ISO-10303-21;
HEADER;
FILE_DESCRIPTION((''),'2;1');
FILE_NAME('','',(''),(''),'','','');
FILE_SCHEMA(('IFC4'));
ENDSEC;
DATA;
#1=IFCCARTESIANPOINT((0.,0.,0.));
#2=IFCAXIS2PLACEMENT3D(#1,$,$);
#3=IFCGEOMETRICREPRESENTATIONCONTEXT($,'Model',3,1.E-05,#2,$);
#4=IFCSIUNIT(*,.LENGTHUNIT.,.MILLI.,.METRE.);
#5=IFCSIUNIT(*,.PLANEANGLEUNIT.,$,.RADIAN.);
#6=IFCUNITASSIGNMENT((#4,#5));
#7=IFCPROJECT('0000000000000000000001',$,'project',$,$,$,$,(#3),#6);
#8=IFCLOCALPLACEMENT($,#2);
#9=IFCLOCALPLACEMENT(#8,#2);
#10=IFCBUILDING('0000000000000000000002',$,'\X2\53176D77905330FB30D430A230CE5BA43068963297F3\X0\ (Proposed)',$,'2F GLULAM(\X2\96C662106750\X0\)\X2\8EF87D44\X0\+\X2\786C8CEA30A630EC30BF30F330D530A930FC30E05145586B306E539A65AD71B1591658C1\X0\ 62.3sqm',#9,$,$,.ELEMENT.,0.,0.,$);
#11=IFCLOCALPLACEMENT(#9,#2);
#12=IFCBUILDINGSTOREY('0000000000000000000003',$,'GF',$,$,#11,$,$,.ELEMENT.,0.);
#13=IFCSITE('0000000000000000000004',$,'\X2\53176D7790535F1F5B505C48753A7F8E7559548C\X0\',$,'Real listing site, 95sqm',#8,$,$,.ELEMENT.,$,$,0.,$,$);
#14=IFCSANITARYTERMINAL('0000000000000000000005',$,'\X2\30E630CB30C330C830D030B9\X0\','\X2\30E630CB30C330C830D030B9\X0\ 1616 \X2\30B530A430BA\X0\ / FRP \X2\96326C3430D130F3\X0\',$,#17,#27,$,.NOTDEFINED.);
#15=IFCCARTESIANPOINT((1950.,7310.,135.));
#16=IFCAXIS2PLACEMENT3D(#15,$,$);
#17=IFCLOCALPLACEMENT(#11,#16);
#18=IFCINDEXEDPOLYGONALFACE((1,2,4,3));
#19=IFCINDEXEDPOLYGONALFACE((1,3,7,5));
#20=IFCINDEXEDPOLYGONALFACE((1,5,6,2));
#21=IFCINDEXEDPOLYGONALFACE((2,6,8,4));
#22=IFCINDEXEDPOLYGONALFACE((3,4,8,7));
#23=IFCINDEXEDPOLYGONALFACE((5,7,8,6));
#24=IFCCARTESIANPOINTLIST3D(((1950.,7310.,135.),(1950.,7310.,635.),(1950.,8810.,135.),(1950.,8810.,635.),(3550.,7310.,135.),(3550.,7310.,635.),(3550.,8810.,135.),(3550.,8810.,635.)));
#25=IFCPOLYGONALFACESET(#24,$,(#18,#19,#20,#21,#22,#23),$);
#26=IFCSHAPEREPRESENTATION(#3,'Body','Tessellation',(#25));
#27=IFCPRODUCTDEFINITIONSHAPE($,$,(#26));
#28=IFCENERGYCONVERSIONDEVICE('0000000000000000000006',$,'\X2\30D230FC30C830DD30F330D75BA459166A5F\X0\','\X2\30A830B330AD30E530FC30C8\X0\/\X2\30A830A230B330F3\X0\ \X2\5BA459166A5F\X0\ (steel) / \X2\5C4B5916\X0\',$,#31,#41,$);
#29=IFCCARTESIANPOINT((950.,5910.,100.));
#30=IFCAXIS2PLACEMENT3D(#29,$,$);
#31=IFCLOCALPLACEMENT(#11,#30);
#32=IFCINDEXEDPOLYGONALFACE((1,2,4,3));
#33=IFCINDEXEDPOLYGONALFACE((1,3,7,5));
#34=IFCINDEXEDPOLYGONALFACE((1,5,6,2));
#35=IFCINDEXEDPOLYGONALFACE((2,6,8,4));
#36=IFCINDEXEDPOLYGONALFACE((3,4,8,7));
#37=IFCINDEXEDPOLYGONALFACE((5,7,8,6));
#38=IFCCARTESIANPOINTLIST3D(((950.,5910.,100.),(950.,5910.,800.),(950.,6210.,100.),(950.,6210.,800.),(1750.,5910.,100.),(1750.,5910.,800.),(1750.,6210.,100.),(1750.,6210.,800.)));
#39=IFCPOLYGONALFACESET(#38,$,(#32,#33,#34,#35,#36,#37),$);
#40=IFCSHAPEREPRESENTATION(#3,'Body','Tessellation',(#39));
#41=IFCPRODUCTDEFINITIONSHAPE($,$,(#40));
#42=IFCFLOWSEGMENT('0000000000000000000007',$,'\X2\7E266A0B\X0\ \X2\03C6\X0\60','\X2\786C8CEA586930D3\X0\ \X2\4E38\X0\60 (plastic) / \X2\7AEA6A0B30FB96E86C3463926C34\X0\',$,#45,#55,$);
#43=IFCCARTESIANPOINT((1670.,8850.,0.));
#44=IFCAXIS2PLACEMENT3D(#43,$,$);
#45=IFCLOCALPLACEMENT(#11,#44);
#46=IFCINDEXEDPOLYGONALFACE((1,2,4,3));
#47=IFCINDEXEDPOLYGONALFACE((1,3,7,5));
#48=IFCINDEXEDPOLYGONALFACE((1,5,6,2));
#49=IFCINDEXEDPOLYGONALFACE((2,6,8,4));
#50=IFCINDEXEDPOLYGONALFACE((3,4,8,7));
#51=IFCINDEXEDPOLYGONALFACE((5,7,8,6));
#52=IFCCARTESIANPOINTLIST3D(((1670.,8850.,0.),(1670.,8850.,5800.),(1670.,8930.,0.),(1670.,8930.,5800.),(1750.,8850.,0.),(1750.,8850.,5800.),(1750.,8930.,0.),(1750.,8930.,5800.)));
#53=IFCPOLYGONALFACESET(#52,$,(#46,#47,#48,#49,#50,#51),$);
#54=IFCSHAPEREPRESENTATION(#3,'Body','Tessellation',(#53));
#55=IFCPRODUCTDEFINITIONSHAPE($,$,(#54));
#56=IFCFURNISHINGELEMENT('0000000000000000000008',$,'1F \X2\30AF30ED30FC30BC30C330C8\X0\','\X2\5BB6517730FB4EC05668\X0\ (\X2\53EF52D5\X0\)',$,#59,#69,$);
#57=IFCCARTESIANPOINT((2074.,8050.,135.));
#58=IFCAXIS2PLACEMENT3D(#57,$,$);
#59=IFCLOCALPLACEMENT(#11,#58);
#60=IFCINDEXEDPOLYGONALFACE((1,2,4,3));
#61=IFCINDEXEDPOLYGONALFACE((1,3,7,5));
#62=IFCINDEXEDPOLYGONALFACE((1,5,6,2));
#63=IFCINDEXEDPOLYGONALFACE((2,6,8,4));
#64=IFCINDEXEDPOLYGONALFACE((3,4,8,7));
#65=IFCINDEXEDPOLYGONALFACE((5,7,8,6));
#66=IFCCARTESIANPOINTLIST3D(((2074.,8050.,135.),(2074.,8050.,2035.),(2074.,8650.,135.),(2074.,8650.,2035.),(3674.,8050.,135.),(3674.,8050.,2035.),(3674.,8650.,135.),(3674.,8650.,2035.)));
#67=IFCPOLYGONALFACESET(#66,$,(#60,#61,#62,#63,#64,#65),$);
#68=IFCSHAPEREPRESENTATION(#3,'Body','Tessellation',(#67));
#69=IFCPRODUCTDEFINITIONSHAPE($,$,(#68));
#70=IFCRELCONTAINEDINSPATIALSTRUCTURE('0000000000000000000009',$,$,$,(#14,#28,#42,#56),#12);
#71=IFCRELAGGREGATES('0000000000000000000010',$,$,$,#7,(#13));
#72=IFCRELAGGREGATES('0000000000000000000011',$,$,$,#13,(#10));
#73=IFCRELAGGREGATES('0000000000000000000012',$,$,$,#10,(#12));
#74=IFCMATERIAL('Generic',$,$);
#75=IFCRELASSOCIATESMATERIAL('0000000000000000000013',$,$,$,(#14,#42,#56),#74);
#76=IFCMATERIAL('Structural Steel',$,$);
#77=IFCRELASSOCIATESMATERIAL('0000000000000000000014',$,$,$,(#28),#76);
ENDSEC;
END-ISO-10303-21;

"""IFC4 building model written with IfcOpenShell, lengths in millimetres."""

from ifc_helpers import new_model, si_unit, frame, frame_2d, origin, place, context, project, spatial, rectangle, extrude, material, element, save


model = new_model("IFC4")

# Units and contexts
model_context = context("Model", 3, precision=1e-05, world=origin())
ifc_project = project(units=[si_unit("LENGTHUNIT", "METRE", prefix="MILLI"), si_unit("PLANEANGLEUNIT", "RADIAN")], contexts=[model_context])

# Site, building, storey
site_placement = place(None, origin())
site = spatial("IfcSite", under=ifc_project, at=site_placement, Name="北海道弟子屈町美留和", ObjectType="Real listing site, 95sqm", CompositionType="ELEMENT", RefElevation=0.0)
building_placement = place(site_placement, origin())
building = spatial("IfcBuilding", under=site, at=building_placement, Name="北海道・ピアノ室と防音 (Proposed)", ObjectType="2F GLULAM(集成材)軸組+硬質ウレタンフォーム充填の厚断熱外壁 62.3sqm", CompositionType="ELEMENT", ElevationOfRefHeight=0.0, ElevationOfTerrain=0.0)
storey_placement = place(building_placement, origin())
storey = spatial("IfcBuildingStorey", under=building, at=storey_placement, Name="GF", CompositionType="ELEMENT", Elevation=0.0)

# Shared definitions
ifc_material_1 = material(Name="Generic")

# Sanitary terminal
sanitary_terminal_placement = place(storey_placement, frame((1950.0, 7310.0, 135.0)))
element("IfcSanitaryTerminal", 1, at=sanitary_terminal_placement, inside=storey, material=ifc_material_1, Name="ユニットバス", Description="ユニットバス 1616 サイズ / FRP 防水パン", PredefinedType="NOTDEFINED", context=model_context, shape_type="SweptSolid", body=[
    extrude(rectangle(XDim=1600.0, YDim=1500.0, at=frame_2d((800.0, 750.0))), frame((1950.0, 7310.0, 135.0)), (0.0, 0.0, 1.0), 500.0),
])

# Energy conversion device
ifc_material_2 = material(Name="Structural Steel")
energy_conversion_device_placement = place(storey_placement, frame((950.0, 5910.0, 100.0)))
element("IfcEnergyConversionDevice", 2, at=energy_conversion_device_placement, inside=storey, material=ifc_material_2, Name="ヒートポンプ室外機", Description="エコキュート/エアコン 室外機 (steel) / 屋外", context=model_context, shape_type="SweptSolid", body=[
    extrude(rectangle(XDim=800.0, YDim=300.0, at=frame_2d((400.0, 150.0))), frame((950.0, 5910.0, 100.0)), (0.0, 0.0, 1.0), 700.0),
])

# Flow segment
flow_segment_placement = place(storey_placement, frame((1670.0, 8850.0, 0.0)))
element("IfcFlowSegment", 3, at=flow_segment_placement, inside=storey, material=ifc_material_1, Name="縦樋 φ60", Description="硬質塩ビ 丸60 (plastic) / 竪樋・雨水排水", context=model_context, shape_type="SweptSolid", body=[
    extrude(rectangle(XDim=80.0, YDim=80.0, at=frame_2d((40.0, 40.0))), frame((1670.0, 8850.0, 0.0)), (0.0, 0.0, 1.0), 5800.0),
])

# Furnishing element
furnishing_placement = place(storey_placement, frame((2074.0, 8050.0, 135.0)))
element("IfcFurnishingElement", 4, at=furnishing_placement, inside=storey, material=ifc_material_1, Name="1F クローゼット", Description="家具・什器 (可動)", context=model_context, shape_type="SweptSolid", body=[
    extrude(rectangle(XDim=1600.0, YDim=600.0, at=frame_2d((800.0, 300.0))), frame((2074.0, 8050.0, 135.0)), (0.0, 0.0, 1.0), 1900.0),
])

save(model, "model.ifc")
